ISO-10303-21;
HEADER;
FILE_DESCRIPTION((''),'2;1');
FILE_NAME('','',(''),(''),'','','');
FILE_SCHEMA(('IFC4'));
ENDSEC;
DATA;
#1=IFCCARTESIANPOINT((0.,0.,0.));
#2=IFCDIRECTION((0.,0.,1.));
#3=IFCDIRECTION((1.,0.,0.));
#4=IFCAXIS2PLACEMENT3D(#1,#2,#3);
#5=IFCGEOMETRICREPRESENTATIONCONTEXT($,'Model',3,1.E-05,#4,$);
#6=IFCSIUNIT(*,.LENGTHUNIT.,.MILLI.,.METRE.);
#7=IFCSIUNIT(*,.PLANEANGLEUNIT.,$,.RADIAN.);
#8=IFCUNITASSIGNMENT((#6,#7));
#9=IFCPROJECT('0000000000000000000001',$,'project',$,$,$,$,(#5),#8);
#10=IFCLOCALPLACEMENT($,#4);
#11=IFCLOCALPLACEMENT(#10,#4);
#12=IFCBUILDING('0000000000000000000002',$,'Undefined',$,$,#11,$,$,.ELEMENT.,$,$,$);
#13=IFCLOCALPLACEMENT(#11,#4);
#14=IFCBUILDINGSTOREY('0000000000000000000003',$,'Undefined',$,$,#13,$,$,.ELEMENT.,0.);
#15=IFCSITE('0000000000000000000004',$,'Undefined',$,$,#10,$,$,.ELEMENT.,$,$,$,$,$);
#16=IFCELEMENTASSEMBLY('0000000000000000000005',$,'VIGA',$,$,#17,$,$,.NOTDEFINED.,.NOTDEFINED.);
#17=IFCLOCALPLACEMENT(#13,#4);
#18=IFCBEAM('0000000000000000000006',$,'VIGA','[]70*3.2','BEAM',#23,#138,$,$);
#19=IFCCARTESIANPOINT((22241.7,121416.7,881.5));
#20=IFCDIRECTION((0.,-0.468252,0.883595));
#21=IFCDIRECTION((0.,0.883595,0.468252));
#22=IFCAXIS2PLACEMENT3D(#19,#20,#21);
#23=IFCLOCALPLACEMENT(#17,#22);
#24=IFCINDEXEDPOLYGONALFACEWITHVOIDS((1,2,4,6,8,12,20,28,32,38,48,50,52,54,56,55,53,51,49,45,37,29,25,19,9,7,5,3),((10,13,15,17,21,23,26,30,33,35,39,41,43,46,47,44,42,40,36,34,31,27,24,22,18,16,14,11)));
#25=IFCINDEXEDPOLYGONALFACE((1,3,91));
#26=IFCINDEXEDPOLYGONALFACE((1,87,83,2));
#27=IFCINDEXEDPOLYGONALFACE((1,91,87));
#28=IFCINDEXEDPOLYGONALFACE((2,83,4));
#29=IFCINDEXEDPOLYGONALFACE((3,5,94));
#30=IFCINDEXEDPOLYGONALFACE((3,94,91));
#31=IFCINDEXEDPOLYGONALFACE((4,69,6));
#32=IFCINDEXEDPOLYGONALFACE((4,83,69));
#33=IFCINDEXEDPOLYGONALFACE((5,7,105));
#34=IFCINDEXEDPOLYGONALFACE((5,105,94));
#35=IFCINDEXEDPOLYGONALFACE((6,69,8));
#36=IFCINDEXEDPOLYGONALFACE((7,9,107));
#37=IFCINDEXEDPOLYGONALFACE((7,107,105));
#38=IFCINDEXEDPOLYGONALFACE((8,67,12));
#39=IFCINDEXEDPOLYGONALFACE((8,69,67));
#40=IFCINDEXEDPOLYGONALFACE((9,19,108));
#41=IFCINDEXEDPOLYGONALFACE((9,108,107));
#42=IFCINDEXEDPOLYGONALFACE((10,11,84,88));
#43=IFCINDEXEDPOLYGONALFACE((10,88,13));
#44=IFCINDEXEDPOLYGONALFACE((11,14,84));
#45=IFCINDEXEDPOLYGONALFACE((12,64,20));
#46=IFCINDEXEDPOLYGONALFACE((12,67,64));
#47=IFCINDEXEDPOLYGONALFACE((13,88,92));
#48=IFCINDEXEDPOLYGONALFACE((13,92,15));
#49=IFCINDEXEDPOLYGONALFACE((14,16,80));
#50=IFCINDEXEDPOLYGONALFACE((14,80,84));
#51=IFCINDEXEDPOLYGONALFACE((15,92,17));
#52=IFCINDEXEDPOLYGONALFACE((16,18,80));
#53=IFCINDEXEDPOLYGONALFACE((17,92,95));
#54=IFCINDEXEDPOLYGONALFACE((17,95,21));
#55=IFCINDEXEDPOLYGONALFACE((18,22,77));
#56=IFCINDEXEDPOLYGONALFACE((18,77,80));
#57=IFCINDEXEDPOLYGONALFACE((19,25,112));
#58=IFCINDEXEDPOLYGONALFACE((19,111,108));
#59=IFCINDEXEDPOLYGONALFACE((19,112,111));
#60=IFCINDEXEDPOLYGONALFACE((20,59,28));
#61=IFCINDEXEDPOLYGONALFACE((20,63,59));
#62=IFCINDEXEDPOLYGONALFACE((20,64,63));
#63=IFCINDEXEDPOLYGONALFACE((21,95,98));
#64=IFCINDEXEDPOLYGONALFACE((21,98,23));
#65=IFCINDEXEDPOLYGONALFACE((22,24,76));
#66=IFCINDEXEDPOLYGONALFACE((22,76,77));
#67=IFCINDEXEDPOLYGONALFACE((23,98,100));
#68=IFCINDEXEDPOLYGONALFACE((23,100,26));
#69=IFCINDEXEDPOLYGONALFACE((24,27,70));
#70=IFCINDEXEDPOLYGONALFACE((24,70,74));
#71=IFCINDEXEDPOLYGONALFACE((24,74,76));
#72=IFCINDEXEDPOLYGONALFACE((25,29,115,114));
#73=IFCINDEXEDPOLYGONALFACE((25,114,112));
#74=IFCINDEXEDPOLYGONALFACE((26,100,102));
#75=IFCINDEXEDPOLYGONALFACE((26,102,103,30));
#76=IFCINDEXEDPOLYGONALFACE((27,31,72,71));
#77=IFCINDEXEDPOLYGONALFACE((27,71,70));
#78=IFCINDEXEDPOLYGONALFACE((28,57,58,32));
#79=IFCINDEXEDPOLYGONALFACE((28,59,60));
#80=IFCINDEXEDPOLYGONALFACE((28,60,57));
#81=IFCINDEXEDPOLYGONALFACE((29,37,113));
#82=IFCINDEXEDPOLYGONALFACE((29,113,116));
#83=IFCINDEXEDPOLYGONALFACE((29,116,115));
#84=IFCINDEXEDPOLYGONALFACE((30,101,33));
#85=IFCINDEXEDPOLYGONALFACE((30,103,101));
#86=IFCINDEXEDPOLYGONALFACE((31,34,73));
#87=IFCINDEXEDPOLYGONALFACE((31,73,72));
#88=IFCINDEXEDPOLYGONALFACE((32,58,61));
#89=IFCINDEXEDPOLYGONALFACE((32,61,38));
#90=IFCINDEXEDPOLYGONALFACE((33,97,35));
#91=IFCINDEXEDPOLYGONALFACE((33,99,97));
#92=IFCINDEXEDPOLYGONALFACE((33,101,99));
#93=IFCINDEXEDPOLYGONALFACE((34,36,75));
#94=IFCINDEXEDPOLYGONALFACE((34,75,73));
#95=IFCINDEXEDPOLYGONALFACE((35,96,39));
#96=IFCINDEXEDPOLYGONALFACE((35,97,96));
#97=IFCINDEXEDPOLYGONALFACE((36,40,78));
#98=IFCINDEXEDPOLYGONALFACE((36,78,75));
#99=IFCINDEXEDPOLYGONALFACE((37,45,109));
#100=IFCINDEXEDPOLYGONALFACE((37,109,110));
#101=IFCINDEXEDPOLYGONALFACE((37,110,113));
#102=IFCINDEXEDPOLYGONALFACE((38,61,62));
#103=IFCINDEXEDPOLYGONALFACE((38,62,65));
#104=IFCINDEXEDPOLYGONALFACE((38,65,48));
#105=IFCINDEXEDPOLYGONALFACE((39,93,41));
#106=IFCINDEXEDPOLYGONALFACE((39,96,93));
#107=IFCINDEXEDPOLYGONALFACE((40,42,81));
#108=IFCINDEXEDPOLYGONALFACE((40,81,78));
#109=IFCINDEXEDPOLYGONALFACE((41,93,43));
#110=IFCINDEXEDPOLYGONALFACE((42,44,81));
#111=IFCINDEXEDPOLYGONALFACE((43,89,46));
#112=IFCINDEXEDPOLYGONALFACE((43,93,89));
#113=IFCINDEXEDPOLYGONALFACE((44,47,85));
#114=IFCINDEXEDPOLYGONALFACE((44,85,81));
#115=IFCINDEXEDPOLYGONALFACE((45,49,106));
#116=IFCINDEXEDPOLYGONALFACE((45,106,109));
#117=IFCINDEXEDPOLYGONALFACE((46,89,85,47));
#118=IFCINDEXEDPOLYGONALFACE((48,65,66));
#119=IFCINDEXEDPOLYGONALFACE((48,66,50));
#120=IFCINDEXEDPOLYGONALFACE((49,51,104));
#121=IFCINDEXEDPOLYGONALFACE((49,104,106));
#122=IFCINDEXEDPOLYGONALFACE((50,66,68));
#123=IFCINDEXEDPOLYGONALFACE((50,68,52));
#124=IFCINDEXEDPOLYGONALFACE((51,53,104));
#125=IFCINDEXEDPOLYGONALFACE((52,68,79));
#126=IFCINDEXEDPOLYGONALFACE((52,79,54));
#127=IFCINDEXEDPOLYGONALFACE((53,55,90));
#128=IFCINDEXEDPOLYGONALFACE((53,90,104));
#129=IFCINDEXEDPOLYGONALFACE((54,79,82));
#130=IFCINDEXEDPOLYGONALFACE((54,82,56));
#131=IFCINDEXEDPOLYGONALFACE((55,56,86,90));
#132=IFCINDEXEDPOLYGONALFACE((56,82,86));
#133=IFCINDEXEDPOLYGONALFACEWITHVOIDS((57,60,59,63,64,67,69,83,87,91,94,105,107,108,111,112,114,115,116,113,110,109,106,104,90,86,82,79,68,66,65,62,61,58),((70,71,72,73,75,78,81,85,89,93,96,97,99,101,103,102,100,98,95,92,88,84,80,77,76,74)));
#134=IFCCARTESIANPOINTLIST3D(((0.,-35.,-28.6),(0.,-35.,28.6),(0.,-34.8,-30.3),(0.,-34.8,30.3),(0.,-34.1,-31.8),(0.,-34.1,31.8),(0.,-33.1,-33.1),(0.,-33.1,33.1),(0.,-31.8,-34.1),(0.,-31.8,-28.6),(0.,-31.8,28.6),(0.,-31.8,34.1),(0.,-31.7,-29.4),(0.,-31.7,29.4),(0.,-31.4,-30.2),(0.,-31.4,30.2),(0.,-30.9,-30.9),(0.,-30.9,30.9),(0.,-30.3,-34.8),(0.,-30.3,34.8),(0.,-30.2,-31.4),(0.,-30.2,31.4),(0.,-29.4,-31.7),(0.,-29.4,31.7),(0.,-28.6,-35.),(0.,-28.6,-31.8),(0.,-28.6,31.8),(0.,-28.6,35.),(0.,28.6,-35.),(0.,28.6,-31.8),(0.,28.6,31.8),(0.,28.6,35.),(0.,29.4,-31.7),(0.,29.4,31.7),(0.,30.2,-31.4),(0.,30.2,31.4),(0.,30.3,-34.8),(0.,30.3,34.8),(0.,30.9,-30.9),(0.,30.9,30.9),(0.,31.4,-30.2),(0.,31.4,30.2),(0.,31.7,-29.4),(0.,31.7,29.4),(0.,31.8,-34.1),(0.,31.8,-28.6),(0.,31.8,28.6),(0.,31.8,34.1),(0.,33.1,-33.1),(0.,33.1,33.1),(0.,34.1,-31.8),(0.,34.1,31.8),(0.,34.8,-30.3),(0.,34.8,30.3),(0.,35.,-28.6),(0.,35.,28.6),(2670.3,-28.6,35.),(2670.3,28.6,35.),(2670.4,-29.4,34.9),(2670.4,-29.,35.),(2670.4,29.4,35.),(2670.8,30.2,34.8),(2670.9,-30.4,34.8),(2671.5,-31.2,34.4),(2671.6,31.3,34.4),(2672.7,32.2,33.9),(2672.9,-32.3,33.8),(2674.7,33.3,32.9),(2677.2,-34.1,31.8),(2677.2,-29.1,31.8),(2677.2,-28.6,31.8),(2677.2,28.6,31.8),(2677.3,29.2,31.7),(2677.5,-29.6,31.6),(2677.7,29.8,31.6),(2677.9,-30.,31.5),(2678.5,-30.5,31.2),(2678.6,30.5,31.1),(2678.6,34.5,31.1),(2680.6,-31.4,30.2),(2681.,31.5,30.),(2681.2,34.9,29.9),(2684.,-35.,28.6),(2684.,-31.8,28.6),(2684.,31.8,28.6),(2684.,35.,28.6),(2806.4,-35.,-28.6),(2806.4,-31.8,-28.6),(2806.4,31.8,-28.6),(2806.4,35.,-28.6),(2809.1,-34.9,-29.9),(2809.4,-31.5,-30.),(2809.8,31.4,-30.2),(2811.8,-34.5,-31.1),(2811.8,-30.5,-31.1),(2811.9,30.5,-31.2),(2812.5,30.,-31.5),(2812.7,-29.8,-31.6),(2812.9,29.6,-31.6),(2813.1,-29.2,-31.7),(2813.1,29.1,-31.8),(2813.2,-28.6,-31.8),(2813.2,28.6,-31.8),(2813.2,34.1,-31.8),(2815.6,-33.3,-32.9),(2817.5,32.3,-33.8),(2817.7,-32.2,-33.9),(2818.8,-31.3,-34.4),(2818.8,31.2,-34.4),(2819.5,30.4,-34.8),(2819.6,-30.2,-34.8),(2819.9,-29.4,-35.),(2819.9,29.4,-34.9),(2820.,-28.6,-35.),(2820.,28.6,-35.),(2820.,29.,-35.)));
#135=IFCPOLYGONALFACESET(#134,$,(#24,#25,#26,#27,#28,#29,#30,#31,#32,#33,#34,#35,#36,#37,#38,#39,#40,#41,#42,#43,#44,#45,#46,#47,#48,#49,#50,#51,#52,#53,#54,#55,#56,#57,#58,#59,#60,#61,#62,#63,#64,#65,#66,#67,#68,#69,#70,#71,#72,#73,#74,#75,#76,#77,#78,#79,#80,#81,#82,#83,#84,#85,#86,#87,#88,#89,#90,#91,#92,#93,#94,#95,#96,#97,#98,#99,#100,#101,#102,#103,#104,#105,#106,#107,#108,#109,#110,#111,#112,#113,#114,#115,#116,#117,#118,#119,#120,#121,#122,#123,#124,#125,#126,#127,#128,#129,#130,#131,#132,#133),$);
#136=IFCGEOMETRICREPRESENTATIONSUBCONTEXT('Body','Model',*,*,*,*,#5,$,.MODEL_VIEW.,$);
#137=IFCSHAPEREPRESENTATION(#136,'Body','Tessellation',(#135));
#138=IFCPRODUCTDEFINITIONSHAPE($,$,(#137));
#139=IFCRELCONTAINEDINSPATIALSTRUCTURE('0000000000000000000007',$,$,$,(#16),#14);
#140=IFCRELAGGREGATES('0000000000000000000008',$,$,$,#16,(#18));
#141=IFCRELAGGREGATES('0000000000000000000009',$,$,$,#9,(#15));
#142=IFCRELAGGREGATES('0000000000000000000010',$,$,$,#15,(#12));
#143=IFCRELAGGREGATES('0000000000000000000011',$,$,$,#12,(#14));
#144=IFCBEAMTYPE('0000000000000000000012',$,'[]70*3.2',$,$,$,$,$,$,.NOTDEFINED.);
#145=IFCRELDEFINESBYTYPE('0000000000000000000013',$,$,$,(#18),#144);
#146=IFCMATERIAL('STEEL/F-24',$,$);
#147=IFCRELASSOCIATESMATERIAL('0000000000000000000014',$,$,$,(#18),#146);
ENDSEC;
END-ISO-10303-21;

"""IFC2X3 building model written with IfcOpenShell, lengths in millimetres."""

from ifc_helpers import new_model, si_unit, frame, origin_with_axes, origin_2d_with_axis, place, context, subcontext, project, spatial, hollow_rectangle, extrude, clip, halfspace, material, type_object, element, aggregate, save


model = new_model("IFC2X3")

# Units and contexts
model_context = context("Model", 3, precision=1e-05, world=origin_with_axes())
body_context = subcontext(model_context, "Body", "Model", "MODEL_VIEW")
ifc_project = project(units=[si_unit("LENGTHUNIT", "METRE", prefix="MILLI"), si_unit("PLANEANGLEUNIT", "RADIAN")], contexts=[model_context])

# Site, building, storey
site_placement = place(None, origin_with_axes())
site = spatial("IfcSite", under=ifc_project, at=site_placement, Name="Undefined", CompositionType="ELEMENT")
building_placement = place(site_placement, origin_with_axes())
building = spatial("IfcBuilding", under=site, at=building_placement, Name="Undefined", CompositionType="ELEMENT")
storey_placement = place(building_placement, origin_with_axes())
storey = spatial("IfcBuildingStorey", under=building, at=storey_placement, Name="Undefined", CompositionType="ELEMENT", Elevation=0.0)

# Element assembly, beam
assembly_1_placement = place(storey_placement, origin_with_axes())
assembly_1 = element("IfcElementAssembly", 1, at=assembly_1_placement, inside=storey, Name="VIGA", AssemblyPlace="NOTDEFINED", PredefinedType="NOTDEFINED")
ifc_material_1 = material(Name="STEEL/F-24")
beam_type_1 = type_object("IfcBeamType", Name="[]70*3.2", PredefinedType="NOTDEFINED")
beam_1_placement = place(assembly_1_placement, frame((22241.7, 121416.7, 881.5), z_axis=(0.0, -0.468252, 0.883595), x_axis=(0.0, 0.883595, 0.468252)))
beam_1 = element("IfcBeam", 2, at=beam_1_placement, type_object=beam_type_1, material=ifc_material_1, Name="VIGA", Description="[]70*3.2", ObjectType="BEAM", context=body_context, shape_type="Clipping", body=[
    clip(extrude(hollow_rectangle(XDim=70.0, YDim=70.0, WallThickness=3.2, InnerFilletRadius=3.2, OuterFilletRadius=6.4, at=origin_2d_with_axis()), frame((2850.0, 0.0, 0.0), z_axis=(-1.0, 0.0, 0.0), x_axis=(0.0, -1.0, 0.0)), (0.0, 0.0, 1.0), 2850.0), halfspace(frame((2745.2, 0.0, 0.0), z_axis=(-0.423531, 0.0, -0.905881), x_axis=(0.0, -1.0, 0.0)), True)),
])

aggregate(assembly_1, [beam_1])

save(model, "model.ifc")
